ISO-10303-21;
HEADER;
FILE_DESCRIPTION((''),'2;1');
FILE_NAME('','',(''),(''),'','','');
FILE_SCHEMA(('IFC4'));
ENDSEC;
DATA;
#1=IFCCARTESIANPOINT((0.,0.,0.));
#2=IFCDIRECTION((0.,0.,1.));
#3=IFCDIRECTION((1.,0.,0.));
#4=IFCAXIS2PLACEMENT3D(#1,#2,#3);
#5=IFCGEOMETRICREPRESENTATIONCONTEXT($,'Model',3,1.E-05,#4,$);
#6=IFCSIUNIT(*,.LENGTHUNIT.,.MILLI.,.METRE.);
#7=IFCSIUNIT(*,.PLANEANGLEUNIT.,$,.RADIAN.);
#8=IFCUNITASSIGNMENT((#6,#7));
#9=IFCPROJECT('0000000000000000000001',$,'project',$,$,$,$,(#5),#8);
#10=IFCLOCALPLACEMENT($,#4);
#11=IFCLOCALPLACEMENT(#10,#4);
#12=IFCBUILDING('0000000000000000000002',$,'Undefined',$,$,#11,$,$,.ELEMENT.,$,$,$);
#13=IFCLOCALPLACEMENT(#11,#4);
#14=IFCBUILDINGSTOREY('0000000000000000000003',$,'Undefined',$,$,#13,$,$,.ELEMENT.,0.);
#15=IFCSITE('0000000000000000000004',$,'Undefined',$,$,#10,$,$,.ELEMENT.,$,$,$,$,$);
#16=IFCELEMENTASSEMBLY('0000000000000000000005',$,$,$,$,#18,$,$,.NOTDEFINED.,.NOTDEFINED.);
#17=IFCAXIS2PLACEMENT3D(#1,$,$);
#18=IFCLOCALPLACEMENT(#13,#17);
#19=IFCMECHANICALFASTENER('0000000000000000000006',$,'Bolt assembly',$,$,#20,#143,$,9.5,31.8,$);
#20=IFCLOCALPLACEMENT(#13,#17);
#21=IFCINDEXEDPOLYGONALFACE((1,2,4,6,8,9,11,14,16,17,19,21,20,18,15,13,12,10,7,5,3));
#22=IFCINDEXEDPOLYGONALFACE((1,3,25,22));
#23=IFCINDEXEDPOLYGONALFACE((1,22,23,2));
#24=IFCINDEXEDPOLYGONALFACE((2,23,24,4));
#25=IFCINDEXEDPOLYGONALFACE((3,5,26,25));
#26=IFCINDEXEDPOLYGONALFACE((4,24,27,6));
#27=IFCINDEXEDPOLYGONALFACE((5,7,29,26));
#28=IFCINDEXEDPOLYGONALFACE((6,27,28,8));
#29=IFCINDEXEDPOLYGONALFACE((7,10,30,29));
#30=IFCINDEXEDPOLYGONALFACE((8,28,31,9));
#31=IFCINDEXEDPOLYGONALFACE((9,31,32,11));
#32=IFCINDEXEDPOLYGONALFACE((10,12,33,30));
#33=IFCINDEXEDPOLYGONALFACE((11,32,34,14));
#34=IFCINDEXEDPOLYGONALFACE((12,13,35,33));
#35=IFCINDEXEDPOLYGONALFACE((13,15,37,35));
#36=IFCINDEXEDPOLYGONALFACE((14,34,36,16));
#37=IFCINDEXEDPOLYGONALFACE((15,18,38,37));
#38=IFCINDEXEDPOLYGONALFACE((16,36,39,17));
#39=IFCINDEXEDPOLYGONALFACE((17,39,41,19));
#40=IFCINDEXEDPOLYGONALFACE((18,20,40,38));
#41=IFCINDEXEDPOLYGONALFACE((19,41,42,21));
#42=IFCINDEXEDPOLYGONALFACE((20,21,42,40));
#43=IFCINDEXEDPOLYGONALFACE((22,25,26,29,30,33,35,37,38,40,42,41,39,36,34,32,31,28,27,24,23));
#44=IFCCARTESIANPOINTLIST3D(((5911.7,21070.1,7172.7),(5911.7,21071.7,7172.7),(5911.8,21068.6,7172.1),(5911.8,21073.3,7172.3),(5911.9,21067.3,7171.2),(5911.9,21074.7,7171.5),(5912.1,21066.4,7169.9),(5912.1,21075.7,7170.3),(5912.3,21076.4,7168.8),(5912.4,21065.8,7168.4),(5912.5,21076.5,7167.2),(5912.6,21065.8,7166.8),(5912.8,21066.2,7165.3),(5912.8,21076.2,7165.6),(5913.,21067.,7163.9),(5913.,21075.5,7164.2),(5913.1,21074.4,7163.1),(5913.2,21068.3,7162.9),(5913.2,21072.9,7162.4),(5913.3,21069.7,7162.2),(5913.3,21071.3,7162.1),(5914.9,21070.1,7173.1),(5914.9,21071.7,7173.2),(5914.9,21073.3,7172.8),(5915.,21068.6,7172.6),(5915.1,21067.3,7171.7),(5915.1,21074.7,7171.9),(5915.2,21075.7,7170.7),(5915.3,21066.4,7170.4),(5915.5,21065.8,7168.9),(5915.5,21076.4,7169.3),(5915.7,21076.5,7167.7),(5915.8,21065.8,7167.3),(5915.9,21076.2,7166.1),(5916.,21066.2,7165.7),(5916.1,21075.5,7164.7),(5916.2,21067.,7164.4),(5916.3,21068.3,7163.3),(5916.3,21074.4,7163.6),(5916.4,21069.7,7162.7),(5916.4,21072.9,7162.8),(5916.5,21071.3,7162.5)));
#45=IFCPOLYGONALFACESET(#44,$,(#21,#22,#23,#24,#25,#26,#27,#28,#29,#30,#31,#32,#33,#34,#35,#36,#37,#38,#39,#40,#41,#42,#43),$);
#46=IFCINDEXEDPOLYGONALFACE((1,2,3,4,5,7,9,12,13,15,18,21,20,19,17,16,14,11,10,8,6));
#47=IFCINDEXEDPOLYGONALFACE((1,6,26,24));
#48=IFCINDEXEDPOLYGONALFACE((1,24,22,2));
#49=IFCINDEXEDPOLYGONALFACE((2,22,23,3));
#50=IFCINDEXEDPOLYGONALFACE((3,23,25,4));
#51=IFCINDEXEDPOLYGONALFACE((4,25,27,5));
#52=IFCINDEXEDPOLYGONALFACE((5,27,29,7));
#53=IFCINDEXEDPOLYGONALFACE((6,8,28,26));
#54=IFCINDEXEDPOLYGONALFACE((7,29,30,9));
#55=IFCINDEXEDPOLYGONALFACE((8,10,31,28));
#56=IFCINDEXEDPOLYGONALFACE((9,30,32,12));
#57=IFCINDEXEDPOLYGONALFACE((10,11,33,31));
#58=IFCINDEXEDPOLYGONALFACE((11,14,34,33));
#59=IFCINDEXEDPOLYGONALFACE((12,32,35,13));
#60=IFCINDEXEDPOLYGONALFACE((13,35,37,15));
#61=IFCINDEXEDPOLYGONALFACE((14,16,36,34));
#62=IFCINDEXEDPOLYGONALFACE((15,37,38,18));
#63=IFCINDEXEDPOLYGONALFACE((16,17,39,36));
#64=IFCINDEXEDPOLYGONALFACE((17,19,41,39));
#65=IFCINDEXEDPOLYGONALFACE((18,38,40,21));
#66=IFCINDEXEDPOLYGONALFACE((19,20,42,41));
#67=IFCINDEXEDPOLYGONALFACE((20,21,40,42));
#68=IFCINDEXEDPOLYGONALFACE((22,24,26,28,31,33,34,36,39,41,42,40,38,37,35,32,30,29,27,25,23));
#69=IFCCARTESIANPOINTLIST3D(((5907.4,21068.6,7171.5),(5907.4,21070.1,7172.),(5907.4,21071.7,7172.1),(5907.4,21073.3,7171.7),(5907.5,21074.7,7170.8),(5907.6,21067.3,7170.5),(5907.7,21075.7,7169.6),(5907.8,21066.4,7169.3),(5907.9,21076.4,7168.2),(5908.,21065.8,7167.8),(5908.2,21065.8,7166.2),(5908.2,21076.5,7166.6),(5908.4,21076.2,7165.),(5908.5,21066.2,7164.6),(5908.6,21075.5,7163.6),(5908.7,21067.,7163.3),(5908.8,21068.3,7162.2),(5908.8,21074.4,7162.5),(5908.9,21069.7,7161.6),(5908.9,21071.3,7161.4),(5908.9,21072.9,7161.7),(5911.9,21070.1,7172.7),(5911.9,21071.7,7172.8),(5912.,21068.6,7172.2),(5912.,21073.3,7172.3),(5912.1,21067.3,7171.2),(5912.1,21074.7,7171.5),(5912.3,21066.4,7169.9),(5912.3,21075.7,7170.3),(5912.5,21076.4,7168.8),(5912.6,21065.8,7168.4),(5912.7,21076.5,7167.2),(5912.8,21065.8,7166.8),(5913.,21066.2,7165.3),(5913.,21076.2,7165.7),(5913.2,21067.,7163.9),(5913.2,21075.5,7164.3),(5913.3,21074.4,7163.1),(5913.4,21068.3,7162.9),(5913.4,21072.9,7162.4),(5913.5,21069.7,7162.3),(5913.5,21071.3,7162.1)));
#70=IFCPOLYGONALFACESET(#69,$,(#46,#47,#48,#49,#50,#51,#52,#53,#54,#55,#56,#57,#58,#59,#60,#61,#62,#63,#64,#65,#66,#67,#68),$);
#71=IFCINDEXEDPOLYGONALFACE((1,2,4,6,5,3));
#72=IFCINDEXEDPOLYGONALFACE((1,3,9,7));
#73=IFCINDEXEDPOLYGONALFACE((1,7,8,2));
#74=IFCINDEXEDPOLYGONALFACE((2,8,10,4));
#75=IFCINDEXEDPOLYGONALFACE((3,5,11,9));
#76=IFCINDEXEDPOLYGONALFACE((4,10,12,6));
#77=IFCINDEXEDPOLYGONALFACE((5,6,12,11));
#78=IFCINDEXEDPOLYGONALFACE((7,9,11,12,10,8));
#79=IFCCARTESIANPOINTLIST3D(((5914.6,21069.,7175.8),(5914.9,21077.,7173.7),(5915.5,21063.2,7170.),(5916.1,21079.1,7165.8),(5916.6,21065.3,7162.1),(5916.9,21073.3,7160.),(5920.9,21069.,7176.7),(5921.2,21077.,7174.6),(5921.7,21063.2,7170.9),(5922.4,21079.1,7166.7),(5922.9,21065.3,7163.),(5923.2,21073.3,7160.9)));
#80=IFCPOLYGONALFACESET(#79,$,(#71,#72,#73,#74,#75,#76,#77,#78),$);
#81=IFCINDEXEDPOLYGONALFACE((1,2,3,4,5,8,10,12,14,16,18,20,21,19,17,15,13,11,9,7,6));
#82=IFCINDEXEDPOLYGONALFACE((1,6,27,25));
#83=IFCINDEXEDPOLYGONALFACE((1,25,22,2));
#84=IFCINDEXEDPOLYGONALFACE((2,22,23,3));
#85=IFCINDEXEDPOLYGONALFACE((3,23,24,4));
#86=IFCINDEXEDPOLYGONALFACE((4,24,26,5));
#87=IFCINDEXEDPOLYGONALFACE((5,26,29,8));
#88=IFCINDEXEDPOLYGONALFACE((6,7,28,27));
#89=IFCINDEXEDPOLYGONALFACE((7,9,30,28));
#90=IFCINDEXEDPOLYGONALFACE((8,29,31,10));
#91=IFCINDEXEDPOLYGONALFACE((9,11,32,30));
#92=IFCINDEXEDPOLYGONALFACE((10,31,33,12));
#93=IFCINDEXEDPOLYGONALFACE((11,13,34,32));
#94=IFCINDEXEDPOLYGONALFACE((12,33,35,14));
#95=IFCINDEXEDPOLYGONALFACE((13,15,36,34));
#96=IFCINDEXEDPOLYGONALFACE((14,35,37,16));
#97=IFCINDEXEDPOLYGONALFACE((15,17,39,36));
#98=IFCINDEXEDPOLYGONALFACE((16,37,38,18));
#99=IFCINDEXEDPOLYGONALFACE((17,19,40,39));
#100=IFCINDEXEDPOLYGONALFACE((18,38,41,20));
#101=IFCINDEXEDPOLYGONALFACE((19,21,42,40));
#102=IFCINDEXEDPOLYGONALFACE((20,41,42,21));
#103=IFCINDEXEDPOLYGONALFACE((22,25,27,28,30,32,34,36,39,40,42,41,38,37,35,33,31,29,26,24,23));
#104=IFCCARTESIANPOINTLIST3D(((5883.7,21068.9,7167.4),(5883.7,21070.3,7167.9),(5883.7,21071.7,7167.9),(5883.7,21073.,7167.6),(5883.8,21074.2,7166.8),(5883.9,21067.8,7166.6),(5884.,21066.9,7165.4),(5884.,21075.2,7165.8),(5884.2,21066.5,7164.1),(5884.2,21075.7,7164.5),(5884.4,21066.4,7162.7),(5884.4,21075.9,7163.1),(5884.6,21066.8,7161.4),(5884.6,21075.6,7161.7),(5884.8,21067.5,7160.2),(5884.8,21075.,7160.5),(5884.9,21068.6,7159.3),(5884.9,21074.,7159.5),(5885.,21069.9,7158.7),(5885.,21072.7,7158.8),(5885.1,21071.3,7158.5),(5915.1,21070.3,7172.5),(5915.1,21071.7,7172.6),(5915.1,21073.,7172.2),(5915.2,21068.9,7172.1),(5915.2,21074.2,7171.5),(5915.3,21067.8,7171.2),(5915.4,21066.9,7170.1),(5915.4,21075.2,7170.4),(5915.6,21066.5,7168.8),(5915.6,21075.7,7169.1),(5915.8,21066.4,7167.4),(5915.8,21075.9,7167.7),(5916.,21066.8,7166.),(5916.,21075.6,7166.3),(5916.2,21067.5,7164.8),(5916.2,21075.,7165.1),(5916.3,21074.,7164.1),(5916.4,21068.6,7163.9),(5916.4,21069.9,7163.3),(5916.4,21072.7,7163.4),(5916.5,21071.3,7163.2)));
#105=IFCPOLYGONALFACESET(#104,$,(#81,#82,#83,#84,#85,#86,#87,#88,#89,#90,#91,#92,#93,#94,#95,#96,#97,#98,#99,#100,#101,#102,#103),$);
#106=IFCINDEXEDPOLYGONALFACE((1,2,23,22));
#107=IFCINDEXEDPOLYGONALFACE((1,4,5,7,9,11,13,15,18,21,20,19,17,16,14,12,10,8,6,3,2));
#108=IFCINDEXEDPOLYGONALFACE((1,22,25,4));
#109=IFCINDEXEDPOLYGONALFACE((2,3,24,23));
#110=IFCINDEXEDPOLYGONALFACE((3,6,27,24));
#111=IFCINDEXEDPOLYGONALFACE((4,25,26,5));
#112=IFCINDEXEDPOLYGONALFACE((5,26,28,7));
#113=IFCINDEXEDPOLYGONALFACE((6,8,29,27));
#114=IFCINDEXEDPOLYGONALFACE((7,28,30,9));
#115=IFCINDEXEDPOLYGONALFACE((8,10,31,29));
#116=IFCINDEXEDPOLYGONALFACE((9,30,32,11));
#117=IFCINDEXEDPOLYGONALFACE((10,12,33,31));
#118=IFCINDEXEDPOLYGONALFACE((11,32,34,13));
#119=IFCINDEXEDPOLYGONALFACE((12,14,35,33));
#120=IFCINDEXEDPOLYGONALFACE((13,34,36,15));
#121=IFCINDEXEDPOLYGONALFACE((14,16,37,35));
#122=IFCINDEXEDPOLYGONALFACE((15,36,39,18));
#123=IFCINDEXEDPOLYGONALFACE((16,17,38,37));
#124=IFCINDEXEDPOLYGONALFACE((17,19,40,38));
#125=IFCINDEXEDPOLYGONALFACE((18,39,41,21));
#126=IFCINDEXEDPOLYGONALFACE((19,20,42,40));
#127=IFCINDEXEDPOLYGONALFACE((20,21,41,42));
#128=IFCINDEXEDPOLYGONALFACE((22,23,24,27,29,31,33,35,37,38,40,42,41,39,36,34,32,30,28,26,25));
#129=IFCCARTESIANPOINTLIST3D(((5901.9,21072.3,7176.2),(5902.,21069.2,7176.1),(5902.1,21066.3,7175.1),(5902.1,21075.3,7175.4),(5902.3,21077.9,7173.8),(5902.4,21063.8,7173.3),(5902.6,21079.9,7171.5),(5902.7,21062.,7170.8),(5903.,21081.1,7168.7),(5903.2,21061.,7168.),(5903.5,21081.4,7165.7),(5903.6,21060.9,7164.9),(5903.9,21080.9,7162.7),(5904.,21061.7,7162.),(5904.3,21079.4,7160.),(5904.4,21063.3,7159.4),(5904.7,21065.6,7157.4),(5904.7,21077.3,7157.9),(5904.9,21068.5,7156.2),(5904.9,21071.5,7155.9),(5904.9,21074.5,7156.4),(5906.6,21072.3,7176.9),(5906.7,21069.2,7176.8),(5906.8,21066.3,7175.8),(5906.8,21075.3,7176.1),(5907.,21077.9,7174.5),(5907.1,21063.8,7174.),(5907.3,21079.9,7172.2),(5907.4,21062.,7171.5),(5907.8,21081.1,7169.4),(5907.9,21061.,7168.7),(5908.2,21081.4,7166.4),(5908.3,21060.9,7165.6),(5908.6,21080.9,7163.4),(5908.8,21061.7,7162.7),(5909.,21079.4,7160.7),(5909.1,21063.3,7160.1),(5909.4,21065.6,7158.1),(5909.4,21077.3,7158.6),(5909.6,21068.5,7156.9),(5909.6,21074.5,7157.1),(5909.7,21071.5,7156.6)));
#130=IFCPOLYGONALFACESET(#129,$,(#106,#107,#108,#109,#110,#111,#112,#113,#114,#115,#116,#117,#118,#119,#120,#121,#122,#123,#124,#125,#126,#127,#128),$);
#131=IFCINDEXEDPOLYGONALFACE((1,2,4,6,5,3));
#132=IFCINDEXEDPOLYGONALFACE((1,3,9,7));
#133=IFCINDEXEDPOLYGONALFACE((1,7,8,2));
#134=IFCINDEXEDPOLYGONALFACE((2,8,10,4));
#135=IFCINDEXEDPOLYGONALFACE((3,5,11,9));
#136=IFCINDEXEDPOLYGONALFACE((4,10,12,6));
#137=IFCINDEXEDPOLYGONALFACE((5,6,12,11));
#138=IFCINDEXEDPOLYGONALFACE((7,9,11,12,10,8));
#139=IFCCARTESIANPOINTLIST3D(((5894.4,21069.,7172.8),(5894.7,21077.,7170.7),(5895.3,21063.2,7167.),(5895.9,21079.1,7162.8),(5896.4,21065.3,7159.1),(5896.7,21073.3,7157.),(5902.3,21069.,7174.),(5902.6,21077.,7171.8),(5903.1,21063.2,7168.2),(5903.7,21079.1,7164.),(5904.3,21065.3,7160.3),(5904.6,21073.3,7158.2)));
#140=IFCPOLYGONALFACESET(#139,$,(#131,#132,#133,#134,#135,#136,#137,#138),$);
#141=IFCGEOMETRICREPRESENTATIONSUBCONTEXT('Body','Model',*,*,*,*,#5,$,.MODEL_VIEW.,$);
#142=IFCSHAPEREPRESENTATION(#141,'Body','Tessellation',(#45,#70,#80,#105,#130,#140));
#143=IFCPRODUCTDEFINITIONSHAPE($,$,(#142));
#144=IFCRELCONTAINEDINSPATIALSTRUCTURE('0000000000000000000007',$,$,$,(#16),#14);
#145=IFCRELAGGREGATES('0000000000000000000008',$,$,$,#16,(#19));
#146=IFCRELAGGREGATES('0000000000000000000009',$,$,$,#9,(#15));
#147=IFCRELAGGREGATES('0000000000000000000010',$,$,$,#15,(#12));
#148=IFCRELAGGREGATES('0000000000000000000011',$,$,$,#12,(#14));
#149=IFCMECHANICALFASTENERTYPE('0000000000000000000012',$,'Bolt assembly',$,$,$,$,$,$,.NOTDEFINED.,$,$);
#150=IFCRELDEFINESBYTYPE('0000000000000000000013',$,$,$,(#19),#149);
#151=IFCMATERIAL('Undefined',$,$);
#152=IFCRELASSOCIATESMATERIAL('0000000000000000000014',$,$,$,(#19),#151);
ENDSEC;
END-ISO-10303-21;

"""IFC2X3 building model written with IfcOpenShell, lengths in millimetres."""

from ifc_helpers import new_model, si_unit, frame, origin_with_axes, origin_2d_with_axis, place, context, subcontext, project, spatial, polyline, circle, outline, extrude, source, transform, mapped, material, type_object, element, aggregate, save


model = new_model("IFC2X3")

# Units and contexts
model_context = context("Model", 3, precision=1e-05, world=origin_with_axes())
body_context = subcontext(model_context, "Body", "Model", "MODEL_VIEW")
ifc_project = project(units=[si_unit("LENGTHUNIT", "METRE", prefix="MILLI"), si_unit("PLANEANGLEUNIT", "RADIAN")], contexts=[model_context])

# Site, building, storey
site_placement = place(None, origin_with_axes())
site = spatial("IfcSite", under=ifc_project, at=site_placement, Name="Undefined", CompositionType="ELEMENT")
building_placement = place(site_placement, origin_with_axes())
building = spatial("IfcBuilding", under=site, at=building_placement, Name="Undefined", CompositionType="ELEMENT")
storey_placement = place(building_placement, origin_with_axes())
storey = spatial("IfcBuildingStorey", under=building, at=storey_placement, Name="Undefined", CompositionType="ELEMENT", Elevation=0.0)

# Element assembly
assembly_1_placement = place(storey_placement, origin_with_axes())
assembly_1 = element("IfcElementAssembly", 1, at=assembly_1_placement, inside=storey, AssemblyPlace="NOTDEFINED", PredefinedType="NOTDEFINED")

# Shared definitions
ifc_material_1 = material(Name="Undefined")
mechanical_fastener_type = type_object("IfcMechanicalFastenerType", Name="Bolt assembly")

# Mechanical fastener
shared_shape_1 = source(origin_with_axes(), body_context, "Body", "SweptSolid", [
    extrude(circle(Radius=5.4, at=origin_2d_with_axis()), frame((0.0, -3.1, 0.0), z_axis=(0.0, 1.0, 0.0), x_axis=(1.0, 0.0, 0.0)), (0.0, 0.0, 1.0), 3.2),
    extrude(circle(Radius=5.4, at=origin_2d_with_axis()), frame((0.0, -0.1, 0.0), z_axis=(0.0, 1.0, 0.0), x_axis=(1.0, 0.0, 0.0)), (0.0, 0.0, 1.0), 4.6),
    extrude(outline(polyline([(7.1, -4.1), (7.1, 4.1), (0.0, 8.2), (-7.1, 4.1), (-7.1, -4.1), (0.0, -8.2), (7.1, -4.1)])), frame((0.0, -9.6, 0.0), z_axis=(0.0, 1.0, 0.0), x_axis=(1.0, 0.0, 0.0)), (0.0, 0.0, 1.0), 6.3),
    extrude(circle(Radius=4.8, at=origin_2d_with_axis()), frame((0.0, -3.2, 0.0), z_axis=(0.0, 1.0, 0.0), x_axis=(1.0, 0.0, 0.0)), (0.0, 0.0, 1.0), 31.8),
    extrude(circle(Radius=10.3, at=origin_2d_with_axis()), frame((0.0, 4.5, 0.0), z_axis=(0.0, 1.0, 0.0), x_axis=(1.0, 0.0, 0.0)), (0.0, 0.0, 1.0), 4.8),
    extrude(outline(polyline([(7.1, -4.1), (7.1, 4.1), (0.0, 8.2), (-7.1, 4.1), (-7.1, -4.1), (0.0, -8.2), (7.1, -4.1)])), frame((0.0, 9.3, 0.0), z_axis=(0.0, 1.0, 0.0), x_axis=(1.0, 0.0, 0.0)), (0.0, 0.0, 1.0), 7.9),
])
mechanical_fastener_1_placement = place(assembly_1_placement, frame((5912.6, 21071.1, 7167.4), z_axis=(0.103381, -0.707107, -0.699509), x_axis=(-0.103381, -0.707107, 0.699509)))
mechanical_fastener_1 = element("IfcMechanicalFastener", 2, at=mechanical_fastener_1_placement, type_object=mechanical_fastener_type, material=ifc_material_1, Name="Bolt assembly", NominalDiameter=9.5, NominalLength=31.8, context=body_context, shape_type="MappedRepresentation", body=[
    mapped(shared_shape_1, transform((0.0, 0.0, 0.0))),
])
aggregate(assembly_1, [mechanical_fastener_1])

save(model, "model.ifc")
